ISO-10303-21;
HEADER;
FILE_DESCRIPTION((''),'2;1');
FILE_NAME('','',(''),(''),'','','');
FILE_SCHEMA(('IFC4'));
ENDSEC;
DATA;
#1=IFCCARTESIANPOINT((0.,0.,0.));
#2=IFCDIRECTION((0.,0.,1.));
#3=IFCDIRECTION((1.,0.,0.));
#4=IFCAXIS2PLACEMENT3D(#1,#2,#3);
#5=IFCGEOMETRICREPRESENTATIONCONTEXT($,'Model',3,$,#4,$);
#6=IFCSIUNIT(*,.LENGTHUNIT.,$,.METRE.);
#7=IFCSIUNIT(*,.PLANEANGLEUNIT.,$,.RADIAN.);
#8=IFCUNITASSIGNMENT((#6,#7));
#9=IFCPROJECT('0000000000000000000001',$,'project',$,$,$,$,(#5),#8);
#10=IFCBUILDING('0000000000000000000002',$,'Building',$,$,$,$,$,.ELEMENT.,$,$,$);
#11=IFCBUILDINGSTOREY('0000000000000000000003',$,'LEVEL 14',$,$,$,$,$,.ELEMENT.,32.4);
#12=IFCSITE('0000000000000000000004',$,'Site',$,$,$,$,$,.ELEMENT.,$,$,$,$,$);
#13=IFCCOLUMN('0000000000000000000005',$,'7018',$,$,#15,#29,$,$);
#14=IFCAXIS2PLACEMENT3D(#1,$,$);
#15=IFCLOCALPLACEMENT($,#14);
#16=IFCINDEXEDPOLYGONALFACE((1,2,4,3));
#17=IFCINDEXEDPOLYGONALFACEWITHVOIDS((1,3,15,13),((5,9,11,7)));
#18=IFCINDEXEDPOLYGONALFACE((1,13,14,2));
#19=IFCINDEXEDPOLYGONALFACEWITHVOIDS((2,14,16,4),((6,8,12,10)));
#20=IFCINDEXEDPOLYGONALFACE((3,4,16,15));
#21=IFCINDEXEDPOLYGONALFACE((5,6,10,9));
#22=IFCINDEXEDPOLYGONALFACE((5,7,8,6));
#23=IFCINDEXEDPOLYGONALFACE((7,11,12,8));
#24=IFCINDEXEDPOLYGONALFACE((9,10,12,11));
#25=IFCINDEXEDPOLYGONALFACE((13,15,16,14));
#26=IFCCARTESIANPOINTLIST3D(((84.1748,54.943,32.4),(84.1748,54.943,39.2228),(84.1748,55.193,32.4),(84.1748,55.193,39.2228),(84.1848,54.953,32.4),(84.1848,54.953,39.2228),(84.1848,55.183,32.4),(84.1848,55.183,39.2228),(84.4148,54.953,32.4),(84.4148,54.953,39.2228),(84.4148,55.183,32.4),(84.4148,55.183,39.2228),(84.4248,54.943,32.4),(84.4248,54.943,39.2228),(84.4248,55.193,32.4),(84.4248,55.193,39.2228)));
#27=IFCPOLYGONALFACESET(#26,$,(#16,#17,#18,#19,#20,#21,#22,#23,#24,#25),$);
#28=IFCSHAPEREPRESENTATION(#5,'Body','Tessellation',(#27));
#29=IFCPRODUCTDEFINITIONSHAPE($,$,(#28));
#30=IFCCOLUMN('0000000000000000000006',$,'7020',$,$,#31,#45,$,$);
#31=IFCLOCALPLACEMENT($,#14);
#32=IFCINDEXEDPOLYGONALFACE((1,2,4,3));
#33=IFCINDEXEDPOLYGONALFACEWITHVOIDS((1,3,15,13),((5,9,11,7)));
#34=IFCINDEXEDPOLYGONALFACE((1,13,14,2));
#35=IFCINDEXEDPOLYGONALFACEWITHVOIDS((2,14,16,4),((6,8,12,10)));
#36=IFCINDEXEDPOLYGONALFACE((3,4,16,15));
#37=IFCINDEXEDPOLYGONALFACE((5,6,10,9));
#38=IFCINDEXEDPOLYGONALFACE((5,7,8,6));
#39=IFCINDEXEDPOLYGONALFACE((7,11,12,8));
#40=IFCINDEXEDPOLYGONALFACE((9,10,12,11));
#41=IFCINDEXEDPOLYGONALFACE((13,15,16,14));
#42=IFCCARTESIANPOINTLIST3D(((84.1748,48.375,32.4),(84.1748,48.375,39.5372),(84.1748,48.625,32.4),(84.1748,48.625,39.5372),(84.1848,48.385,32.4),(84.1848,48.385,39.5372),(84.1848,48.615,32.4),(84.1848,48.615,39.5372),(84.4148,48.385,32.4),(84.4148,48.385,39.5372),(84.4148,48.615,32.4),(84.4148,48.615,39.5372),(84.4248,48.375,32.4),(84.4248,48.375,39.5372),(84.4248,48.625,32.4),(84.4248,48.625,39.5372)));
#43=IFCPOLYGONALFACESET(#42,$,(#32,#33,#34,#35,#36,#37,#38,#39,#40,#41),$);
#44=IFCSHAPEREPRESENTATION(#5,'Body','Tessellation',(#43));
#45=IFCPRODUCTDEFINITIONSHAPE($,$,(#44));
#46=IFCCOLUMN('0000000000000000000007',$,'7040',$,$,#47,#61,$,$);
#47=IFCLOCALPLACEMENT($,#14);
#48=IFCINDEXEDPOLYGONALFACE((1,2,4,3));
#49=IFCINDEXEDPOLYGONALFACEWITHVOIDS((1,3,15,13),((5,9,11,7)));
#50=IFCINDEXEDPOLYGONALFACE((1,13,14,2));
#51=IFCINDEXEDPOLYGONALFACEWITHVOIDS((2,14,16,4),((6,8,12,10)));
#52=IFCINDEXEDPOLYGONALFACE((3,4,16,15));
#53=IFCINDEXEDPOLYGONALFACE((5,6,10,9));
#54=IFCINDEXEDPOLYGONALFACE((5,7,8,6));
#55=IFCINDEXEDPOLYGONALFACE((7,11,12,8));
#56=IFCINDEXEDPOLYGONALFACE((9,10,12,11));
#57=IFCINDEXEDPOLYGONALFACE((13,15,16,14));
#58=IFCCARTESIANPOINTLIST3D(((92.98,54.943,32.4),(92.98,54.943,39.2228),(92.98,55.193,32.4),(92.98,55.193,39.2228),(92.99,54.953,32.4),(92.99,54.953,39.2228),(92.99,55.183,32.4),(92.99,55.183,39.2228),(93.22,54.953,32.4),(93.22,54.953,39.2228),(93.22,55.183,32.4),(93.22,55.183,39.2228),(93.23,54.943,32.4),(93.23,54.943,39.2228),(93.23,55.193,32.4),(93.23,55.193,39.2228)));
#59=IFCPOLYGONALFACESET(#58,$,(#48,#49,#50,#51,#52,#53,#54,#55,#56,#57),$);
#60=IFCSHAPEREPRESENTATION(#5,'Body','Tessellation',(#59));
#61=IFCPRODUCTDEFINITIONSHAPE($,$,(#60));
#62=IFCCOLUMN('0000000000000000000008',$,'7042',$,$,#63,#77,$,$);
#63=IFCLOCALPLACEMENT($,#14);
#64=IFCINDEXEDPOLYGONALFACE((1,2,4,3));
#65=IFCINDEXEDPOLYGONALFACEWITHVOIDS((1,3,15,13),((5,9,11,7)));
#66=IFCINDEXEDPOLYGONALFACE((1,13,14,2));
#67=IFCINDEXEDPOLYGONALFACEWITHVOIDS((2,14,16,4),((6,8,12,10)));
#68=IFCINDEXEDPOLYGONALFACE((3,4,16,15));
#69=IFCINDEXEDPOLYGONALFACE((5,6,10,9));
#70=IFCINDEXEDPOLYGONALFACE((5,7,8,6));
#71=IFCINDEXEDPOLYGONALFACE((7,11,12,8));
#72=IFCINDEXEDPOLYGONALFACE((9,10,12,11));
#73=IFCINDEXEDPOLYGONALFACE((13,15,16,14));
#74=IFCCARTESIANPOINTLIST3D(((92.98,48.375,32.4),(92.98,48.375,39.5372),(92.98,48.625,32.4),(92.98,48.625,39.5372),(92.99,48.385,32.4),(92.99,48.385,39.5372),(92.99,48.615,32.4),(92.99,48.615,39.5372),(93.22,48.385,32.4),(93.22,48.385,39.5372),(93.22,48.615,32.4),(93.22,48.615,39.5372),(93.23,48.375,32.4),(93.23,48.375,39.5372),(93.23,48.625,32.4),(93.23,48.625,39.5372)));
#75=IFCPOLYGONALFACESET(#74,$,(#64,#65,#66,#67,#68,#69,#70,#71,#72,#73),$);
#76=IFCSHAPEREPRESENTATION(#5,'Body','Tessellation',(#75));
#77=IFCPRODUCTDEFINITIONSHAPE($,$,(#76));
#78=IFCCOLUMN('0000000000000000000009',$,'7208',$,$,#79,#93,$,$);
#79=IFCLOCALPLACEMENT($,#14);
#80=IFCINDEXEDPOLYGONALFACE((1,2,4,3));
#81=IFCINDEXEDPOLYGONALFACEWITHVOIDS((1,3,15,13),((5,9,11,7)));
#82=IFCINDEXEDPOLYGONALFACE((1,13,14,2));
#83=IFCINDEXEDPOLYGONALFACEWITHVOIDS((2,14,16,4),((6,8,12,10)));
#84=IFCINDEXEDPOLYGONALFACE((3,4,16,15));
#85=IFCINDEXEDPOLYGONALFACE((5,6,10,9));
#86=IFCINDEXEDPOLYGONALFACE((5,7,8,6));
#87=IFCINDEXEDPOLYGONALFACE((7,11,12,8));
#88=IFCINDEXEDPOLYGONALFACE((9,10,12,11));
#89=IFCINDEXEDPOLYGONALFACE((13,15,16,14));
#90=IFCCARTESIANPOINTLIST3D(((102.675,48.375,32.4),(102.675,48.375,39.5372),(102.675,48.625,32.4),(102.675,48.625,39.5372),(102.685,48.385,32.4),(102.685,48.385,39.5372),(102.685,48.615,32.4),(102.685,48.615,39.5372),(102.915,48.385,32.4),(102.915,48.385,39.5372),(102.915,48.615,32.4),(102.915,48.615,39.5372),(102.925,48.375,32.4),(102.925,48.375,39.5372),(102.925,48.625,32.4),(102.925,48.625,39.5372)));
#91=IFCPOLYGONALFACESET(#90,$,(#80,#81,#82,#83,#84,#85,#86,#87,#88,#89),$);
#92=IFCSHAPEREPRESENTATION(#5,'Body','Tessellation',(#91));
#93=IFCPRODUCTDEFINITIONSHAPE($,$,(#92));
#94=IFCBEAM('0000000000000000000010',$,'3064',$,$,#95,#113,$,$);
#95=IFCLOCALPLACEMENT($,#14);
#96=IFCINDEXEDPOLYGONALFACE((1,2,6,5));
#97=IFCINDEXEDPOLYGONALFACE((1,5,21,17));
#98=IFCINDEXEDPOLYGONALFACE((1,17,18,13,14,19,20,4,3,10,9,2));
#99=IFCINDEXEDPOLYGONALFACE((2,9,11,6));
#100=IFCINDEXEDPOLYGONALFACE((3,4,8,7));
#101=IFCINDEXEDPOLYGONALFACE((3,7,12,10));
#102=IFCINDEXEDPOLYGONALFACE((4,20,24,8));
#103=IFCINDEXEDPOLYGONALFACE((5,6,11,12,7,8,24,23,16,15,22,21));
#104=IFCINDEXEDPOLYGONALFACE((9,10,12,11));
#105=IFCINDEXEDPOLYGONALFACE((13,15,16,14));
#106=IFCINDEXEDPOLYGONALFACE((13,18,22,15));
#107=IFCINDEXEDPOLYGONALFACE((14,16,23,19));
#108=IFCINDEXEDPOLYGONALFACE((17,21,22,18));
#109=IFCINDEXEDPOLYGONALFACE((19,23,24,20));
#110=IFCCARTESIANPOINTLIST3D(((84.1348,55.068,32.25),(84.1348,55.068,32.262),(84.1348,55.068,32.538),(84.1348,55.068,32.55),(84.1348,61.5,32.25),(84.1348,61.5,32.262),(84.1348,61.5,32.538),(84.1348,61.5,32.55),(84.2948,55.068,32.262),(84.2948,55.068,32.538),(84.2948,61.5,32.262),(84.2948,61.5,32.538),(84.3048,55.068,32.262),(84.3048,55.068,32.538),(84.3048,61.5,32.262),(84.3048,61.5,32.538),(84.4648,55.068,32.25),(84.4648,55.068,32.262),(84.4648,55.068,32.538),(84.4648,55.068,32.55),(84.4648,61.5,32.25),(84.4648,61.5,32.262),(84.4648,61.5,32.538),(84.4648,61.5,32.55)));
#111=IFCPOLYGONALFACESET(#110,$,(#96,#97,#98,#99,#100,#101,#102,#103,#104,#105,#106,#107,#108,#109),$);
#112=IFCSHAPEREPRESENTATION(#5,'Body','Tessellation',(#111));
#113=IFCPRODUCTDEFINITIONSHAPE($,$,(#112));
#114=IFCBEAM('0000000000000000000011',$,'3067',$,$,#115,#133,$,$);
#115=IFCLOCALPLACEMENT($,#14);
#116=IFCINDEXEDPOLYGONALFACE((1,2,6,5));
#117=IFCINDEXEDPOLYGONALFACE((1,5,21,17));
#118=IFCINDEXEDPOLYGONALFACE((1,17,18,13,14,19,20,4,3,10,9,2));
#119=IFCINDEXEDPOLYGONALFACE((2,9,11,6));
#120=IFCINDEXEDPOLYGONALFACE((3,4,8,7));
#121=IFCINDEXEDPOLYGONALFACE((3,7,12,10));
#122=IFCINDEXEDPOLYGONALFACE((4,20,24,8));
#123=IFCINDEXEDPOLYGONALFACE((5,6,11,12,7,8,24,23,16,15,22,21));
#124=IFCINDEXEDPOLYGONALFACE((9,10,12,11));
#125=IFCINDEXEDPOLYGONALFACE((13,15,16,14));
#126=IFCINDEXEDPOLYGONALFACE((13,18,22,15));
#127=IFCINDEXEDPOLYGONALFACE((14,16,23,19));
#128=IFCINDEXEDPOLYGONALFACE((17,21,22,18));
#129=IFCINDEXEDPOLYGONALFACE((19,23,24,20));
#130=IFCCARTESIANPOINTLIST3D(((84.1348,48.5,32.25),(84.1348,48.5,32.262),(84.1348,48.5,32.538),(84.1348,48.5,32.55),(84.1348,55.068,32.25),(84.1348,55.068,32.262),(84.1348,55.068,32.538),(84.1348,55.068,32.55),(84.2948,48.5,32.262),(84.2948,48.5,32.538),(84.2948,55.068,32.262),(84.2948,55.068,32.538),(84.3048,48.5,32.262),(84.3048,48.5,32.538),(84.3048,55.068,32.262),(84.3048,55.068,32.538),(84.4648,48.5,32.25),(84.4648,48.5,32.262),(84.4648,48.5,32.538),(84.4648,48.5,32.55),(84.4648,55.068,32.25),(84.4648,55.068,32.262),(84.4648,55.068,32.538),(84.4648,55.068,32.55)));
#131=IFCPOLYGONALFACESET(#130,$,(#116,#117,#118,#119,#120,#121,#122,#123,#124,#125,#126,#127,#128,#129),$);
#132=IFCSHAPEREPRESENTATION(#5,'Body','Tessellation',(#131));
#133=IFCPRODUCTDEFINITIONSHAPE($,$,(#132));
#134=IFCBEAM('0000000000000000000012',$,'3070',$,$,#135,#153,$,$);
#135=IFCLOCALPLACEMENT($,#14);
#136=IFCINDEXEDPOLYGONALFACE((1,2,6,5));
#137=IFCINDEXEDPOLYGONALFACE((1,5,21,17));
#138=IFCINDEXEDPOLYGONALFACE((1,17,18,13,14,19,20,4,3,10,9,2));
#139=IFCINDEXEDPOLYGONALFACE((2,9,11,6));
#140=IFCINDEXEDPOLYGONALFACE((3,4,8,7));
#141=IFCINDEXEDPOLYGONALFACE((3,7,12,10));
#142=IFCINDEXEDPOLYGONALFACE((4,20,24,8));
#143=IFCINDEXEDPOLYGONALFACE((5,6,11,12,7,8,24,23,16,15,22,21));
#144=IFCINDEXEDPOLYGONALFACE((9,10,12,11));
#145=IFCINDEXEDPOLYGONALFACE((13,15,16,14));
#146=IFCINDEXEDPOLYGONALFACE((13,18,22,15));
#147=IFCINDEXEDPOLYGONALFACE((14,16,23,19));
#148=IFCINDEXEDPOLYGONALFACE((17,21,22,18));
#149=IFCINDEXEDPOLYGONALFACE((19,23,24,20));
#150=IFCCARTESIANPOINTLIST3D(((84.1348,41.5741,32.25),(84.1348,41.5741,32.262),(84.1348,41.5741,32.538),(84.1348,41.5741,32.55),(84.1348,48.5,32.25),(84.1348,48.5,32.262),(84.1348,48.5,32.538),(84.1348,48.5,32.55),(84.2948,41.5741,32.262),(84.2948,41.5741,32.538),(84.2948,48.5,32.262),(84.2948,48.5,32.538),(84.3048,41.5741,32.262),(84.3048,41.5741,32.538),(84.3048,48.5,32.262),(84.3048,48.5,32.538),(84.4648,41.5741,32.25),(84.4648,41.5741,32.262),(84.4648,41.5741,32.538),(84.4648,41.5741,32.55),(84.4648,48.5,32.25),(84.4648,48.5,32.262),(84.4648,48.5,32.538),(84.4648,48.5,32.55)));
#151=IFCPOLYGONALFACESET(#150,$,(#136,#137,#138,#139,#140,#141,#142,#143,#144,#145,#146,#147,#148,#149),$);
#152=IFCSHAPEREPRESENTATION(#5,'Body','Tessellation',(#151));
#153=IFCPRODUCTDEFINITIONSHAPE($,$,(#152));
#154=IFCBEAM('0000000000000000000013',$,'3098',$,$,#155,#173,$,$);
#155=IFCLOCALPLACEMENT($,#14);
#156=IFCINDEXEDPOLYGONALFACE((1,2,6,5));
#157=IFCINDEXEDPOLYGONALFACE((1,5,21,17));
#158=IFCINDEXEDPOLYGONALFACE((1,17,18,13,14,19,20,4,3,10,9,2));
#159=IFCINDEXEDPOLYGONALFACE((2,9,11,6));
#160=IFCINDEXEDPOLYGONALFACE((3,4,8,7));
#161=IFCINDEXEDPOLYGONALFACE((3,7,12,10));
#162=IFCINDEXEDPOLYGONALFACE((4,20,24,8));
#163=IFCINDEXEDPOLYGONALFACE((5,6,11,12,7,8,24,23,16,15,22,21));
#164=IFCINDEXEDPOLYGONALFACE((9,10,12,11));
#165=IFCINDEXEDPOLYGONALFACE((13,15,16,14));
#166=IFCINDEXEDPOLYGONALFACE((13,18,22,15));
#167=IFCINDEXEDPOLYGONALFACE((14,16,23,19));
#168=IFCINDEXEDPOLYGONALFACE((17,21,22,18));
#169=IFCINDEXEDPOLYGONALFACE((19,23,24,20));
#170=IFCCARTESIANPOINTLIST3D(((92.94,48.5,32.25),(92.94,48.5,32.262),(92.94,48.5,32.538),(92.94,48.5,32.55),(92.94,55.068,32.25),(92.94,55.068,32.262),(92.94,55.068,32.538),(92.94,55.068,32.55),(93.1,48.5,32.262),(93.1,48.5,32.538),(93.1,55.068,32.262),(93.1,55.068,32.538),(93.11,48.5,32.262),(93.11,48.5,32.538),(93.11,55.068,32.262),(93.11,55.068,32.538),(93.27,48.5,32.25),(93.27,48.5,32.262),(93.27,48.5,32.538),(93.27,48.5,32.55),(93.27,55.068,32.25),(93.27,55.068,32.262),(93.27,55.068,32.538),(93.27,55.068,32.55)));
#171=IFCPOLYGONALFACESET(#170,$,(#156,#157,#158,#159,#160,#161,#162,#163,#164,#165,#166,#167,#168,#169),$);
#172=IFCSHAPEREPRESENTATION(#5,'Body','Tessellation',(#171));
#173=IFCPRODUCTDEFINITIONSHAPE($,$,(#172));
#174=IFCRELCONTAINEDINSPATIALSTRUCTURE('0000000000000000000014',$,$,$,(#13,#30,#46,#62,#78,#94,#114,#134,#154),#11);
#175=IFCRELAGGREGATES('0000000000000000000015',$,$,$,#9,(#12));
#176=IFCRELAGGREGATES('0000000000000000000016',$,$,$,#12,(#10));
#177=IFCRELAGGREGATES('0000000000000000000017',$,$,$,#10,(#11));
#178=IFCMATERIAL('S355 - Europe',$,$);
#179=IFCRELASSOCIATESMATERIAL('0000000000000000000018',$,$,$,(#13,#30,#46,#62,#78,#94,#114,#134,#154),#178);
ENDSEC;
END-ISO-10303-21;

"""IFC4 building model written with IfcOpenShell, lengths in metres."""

from ifc_helpers import new_model, si_unit, frame, origin_with_axes, origin_2d_with_axis, place, context, project, spatial, hollow_rectangle, i_section, extrude, material, material_profile, profile_set, profile_usage, element, save


model = new_model("IFC4")

# Units and contexts
model_context = context("Model", 3, world=origin_with_axes())
ifc_project = project(units=[si_unit("LENGTHUNIT", "METRE"), si_unit("PLANEANGLEUNIT", "RADIAN")], contexts=[model_context])

# Site, building, storey
site = spatial("IfcSite", under=ifc_project, Name="Site", CompositionType="ELEMENT")
building = spatial("IfcBuilding", under=site, Name="Building", CompositionType="ELEMENT")
storey = spatial("IfcBuildingStorey", under=building, Name="LEVEL 14", CompositionType="ELEMENT", Elevation=32.4)

# Columns
ifc_material = material(Name="S355 - Europe")
ifc_material_profile_1 = material_profile(ifc_material, hollow_rectangle(XDim=0.25, YDim=0.25, WallThickness=0.01, at=origin_2d_with_axis()))
ifc_profile_set_1 = profile_set([ifc_material_profile_1])
ifc_profile_usage_1 = profile_usage(ifc_profile_set_1, cardinal=10)
column_1_placement = place(None, frame((84.2998, 55.068, 32.4), z_axis=(0.0, 0.0, 1.0), x_axis=(0.0, -1.0, 0.0)))
element("IfcColumn", 1, at=column_1_placement, inside=storey, material=ifc_profile_usage_1, Name="7018", context=model_context, shape_type="SweptSolid", body=[
    extrude(hollow_rectangle(XDim=0.25, YDim=0.25, WallThickness=0.01, at=origin_2d_with_axis()), origin_with_axes(), (0.0, 0.0, 1.0), 6.8228),
])
ifc_material_profile_2 = material_profile(ifc_material, hollow_rectangle(XDim=0.25, YDim=0.25, WallThickness=0.01, at=origin_2d_with_axis()))
ifc_profile_set_2 = profile_set([ifc_material_profile_2])
ifc_profile_usage_2 = profile_usage(ifc_profile_set_2, cardinal=10)
column_2_placement = place(None, frame((84.2998, 48.5, 32.4), z_axis=(0.0, 0.0, 1.0), x_axis=(0.0, -1.0, 0.0)))
element("IfcColumn", 2, at=column_2_placement, inside=storey, material=ifc_profile_usage_2, Name="7020", context=model_context, shape_type="SweptSolid", body=[
    extrude(hollow_rectangle(XDim=0.25, YDim=0.25, WallThickness=0.01, at=origin_2d_with_axis()), origin_with_axes(), (0.0, 0.0, 1.0), 7.1372),
])
ifc_material_profile_3 = material_profile(ifc_material, hollow_rectangle(XDim=0.25, YDim=0.25, WallThickness=0.01, at=origin_2d_with_axis()))
ifc_profile_set_3 = profile_set([ifc_material_profile_3])
ifc_profile_usage_3 = profile_usage(ifc_profile_set_3, cardinal=10)
column_3_placement = place(None, frame((93.105, 55.068, 32.4), z_axis=(0.0, 0.0, 1.0), x_axis=(0.0, -1.0, 0.0)))
element("IfcColumn", 3, at=column_3_placement, inside=storey, material=ifc_profile_usage_3, Name="7040", context=model_context, shape_type="SweptSolid", body=[
    extrude(hollow_rectangle(XDim=0.25, YDim=0.25, WallThickness=0.01, at=origin_2d_with_axis()), origin_with_axes(), (0.0, 0.0, 1.0), 6.8228),
])
ifc_material_profile_4 = material_profile(ifc_material, hollow_rectangle(XDim=0.25, YDim=0.25, WallThickness=0.01, at=origin_2d_with_axis()))
ifc_profile_set_4 = profile_set([ifc_material_profile_4])
ifc_profile_usage_4 = profile_usage(ifc_profile_set_4, cardinal=10)
column_4_placement = place(None, frame((93.105, 48.5, 32.4), z_axis=(0.0, 0.0, 1.0), x_axis=(0.0, -1.0, 0.0)))
element("IfcColumn", 4, at=column_4_placement, inside=storey, material=ifc_profile_usage_4, Name="7042", context=model_context, shape_type="SweptSolid", body=[
    extrude(hollow_rectangle(XDim=0.25, YDim=0.25, WallThickness=0.01, at=origin_2d_with_axis()), origin_with_axes(), (0.0, 0.0, 1.0), 7.1372),
])
ifc_material_profile_5 = material_profile(ifc_material, hollow_rectangle(XDim=0.25, YDim=0.25, WallThickness=0.01, at=origin_2d_with_axis()))
ifc_profile_set_5 = profile_set([ifc_material_profile_5])
ifc_profile_usage_5 = profile_usage(ifc_profile_set_5, cardinal=10)
column_5_placement = place(None, frame((102.8, 48.5, 32.4), z_axis=(0.0, 0.0, 1.0), x_axis=(0.0, -1.0, 0.0)))
element("IfcColumn", 5, at=column_5_placement, inside=storey, material=ifc_profile_usage_5, Name="7208", context=model_context, shape_type="SweptSolid", body=[
    extrude(hollow_rectangle(XDim=0.25, YDim=0.25, WallThickness=0.01, at=origin_2d_with_axis()), origin_with_axes(), (0.0, 0.0, 1.0), 7.1372),
])

# Beams
ifc_material_profile_6 = material_profile(ifc_material, i_section(OverallWidth=0.33, OverallDepth=0.3, WebThickness=0.01, FlangeThickness=0.012, at=origin_2d_with_axis()))
ifc_profile_set_6 = profile_set([ifc_material_profile_6])
ifc_profile_usage_6 = profile_usage(ifc_profile_set_6, cardinal=10)
beam_1_placement = place(None, frame((84.2998, 55.068, 32.4), z_axis=(0.0, 1.0, 0.0), x_axis=(-1.0, 0.0, 0.0)))
element("IfcBeam", 6, at=beam_1_placement, inside=storey, material=ifc_profile_usage_6, Name="3064", context=model_context, shape_type="SweptSolid", body=[
    extrude(i_section(OverallWidth=0.33, OverallDepth=0.3, WebThickness=0.01, FlangeThickness=0.012, at=origin_2d_with_axis()), origin_with_axes(), (0.0, 0.0, 1.0), 6.432),
])
ifc_material_profile_7 = material_profile(ifc_material, i_section(OverallWidth=0.33, OverallDepth=0.3, WebThickness=0.01, FlangeThickness=0.012, at=origin_2d_with_axis()))
ifc_profile_set_7 = profile_set([ifc_material_profile_7])
ifc_profile_usage_7 = profile_usage(ifc_profile_set_7, cardinal=10)
beam_2_placement = place(None, frame((84.2998, 55.068, 32.4), z_axis=(0.0, -1.0, 0.0), x_axis=(1.0, 0.0, 0.0)))
element("IfcBeam", 7, at=beam_2_placement, inside=storey, material=ifc_profile_usage_7, Name="3067", context=model_context, shape_type="SweptSolid", body=[
    extrude(i_section(OverallWidth=0.33, OverallDepth=0.3, WebThickness=0.01, FlangeThickness=0.012, at=origin_2d_with_axis()), origin_with_axes(), (0.0, 0.0, 1.0), 6.568),
])
ifc_material_profile_8 = material_profile(ifc_material, i_section(OverallWidth=0.33, OverallDepth=0.3, WebThickness=0.01, FlangeThickness=0.012, at=origin_2d_with_axis()))
ifc_profile_set_8 = profile_set([ifc_material_profile_8])
ifc_profile_usage_8 = profile_usage(ifc_profile_set_8, cardinal=10)
beam_3_placement = place(None, frame((84.2998, 48.5, 32.4), z_axis=(0.0, -1.0, 0.0), x_axis=(1.0, 0.0, 0.0)))
element("IfcBeam", 8, at=beam_3_placement, inside=storey, material=ifc_profile_usage_8, Name="3070", context=model_context, shape_type="SweptSolid", body=[
    extrude(i_section(OverallWidth=0.33, OverallDepth=0.3, WebThickness=0.01, FlangeThickness=0.012, at=origin_2d_with_axis()), origin_with_axes(), (0.0, 0.0, 1.0), 6.9259),
])
ifc_material_profile_9 = material_profile(ifc_material, i_section(OverallWidth=0.33, OverallDepth=0.3, WebThickness=0.01, FlangeThickness=0.012, at=origin_2d_with_axis()))
ifc_profile_set_9 = profile_set([ifc_material_profile_9])
ifc_profile_usage_9 = profile_usage(ifc_profile_set_9, cardinal=10)
beam_4_placement = place(None, frame((93.105, 55.068, 32.4), z_axis=(0.0, -1.0, 0.0), x_axis=(1.0, 0.0, 0.0)))
element("IfcBeam", 9, at=beam_4_placement, inside=storey, material=ifc_profile_usage_9, Name="3098", context=model_context, shape_type="SweptSolid", body=[
    extrude(i_section(OverallWidth=0.33, OverallDepth=0.3, WebThickness=0.01, FlangeThickness=0.012, at=origin_2d_with_axis()), origin_with_axes(), (0.0, 0.0, 1.0), 6.568),
])

save(model, "model.ifc")
